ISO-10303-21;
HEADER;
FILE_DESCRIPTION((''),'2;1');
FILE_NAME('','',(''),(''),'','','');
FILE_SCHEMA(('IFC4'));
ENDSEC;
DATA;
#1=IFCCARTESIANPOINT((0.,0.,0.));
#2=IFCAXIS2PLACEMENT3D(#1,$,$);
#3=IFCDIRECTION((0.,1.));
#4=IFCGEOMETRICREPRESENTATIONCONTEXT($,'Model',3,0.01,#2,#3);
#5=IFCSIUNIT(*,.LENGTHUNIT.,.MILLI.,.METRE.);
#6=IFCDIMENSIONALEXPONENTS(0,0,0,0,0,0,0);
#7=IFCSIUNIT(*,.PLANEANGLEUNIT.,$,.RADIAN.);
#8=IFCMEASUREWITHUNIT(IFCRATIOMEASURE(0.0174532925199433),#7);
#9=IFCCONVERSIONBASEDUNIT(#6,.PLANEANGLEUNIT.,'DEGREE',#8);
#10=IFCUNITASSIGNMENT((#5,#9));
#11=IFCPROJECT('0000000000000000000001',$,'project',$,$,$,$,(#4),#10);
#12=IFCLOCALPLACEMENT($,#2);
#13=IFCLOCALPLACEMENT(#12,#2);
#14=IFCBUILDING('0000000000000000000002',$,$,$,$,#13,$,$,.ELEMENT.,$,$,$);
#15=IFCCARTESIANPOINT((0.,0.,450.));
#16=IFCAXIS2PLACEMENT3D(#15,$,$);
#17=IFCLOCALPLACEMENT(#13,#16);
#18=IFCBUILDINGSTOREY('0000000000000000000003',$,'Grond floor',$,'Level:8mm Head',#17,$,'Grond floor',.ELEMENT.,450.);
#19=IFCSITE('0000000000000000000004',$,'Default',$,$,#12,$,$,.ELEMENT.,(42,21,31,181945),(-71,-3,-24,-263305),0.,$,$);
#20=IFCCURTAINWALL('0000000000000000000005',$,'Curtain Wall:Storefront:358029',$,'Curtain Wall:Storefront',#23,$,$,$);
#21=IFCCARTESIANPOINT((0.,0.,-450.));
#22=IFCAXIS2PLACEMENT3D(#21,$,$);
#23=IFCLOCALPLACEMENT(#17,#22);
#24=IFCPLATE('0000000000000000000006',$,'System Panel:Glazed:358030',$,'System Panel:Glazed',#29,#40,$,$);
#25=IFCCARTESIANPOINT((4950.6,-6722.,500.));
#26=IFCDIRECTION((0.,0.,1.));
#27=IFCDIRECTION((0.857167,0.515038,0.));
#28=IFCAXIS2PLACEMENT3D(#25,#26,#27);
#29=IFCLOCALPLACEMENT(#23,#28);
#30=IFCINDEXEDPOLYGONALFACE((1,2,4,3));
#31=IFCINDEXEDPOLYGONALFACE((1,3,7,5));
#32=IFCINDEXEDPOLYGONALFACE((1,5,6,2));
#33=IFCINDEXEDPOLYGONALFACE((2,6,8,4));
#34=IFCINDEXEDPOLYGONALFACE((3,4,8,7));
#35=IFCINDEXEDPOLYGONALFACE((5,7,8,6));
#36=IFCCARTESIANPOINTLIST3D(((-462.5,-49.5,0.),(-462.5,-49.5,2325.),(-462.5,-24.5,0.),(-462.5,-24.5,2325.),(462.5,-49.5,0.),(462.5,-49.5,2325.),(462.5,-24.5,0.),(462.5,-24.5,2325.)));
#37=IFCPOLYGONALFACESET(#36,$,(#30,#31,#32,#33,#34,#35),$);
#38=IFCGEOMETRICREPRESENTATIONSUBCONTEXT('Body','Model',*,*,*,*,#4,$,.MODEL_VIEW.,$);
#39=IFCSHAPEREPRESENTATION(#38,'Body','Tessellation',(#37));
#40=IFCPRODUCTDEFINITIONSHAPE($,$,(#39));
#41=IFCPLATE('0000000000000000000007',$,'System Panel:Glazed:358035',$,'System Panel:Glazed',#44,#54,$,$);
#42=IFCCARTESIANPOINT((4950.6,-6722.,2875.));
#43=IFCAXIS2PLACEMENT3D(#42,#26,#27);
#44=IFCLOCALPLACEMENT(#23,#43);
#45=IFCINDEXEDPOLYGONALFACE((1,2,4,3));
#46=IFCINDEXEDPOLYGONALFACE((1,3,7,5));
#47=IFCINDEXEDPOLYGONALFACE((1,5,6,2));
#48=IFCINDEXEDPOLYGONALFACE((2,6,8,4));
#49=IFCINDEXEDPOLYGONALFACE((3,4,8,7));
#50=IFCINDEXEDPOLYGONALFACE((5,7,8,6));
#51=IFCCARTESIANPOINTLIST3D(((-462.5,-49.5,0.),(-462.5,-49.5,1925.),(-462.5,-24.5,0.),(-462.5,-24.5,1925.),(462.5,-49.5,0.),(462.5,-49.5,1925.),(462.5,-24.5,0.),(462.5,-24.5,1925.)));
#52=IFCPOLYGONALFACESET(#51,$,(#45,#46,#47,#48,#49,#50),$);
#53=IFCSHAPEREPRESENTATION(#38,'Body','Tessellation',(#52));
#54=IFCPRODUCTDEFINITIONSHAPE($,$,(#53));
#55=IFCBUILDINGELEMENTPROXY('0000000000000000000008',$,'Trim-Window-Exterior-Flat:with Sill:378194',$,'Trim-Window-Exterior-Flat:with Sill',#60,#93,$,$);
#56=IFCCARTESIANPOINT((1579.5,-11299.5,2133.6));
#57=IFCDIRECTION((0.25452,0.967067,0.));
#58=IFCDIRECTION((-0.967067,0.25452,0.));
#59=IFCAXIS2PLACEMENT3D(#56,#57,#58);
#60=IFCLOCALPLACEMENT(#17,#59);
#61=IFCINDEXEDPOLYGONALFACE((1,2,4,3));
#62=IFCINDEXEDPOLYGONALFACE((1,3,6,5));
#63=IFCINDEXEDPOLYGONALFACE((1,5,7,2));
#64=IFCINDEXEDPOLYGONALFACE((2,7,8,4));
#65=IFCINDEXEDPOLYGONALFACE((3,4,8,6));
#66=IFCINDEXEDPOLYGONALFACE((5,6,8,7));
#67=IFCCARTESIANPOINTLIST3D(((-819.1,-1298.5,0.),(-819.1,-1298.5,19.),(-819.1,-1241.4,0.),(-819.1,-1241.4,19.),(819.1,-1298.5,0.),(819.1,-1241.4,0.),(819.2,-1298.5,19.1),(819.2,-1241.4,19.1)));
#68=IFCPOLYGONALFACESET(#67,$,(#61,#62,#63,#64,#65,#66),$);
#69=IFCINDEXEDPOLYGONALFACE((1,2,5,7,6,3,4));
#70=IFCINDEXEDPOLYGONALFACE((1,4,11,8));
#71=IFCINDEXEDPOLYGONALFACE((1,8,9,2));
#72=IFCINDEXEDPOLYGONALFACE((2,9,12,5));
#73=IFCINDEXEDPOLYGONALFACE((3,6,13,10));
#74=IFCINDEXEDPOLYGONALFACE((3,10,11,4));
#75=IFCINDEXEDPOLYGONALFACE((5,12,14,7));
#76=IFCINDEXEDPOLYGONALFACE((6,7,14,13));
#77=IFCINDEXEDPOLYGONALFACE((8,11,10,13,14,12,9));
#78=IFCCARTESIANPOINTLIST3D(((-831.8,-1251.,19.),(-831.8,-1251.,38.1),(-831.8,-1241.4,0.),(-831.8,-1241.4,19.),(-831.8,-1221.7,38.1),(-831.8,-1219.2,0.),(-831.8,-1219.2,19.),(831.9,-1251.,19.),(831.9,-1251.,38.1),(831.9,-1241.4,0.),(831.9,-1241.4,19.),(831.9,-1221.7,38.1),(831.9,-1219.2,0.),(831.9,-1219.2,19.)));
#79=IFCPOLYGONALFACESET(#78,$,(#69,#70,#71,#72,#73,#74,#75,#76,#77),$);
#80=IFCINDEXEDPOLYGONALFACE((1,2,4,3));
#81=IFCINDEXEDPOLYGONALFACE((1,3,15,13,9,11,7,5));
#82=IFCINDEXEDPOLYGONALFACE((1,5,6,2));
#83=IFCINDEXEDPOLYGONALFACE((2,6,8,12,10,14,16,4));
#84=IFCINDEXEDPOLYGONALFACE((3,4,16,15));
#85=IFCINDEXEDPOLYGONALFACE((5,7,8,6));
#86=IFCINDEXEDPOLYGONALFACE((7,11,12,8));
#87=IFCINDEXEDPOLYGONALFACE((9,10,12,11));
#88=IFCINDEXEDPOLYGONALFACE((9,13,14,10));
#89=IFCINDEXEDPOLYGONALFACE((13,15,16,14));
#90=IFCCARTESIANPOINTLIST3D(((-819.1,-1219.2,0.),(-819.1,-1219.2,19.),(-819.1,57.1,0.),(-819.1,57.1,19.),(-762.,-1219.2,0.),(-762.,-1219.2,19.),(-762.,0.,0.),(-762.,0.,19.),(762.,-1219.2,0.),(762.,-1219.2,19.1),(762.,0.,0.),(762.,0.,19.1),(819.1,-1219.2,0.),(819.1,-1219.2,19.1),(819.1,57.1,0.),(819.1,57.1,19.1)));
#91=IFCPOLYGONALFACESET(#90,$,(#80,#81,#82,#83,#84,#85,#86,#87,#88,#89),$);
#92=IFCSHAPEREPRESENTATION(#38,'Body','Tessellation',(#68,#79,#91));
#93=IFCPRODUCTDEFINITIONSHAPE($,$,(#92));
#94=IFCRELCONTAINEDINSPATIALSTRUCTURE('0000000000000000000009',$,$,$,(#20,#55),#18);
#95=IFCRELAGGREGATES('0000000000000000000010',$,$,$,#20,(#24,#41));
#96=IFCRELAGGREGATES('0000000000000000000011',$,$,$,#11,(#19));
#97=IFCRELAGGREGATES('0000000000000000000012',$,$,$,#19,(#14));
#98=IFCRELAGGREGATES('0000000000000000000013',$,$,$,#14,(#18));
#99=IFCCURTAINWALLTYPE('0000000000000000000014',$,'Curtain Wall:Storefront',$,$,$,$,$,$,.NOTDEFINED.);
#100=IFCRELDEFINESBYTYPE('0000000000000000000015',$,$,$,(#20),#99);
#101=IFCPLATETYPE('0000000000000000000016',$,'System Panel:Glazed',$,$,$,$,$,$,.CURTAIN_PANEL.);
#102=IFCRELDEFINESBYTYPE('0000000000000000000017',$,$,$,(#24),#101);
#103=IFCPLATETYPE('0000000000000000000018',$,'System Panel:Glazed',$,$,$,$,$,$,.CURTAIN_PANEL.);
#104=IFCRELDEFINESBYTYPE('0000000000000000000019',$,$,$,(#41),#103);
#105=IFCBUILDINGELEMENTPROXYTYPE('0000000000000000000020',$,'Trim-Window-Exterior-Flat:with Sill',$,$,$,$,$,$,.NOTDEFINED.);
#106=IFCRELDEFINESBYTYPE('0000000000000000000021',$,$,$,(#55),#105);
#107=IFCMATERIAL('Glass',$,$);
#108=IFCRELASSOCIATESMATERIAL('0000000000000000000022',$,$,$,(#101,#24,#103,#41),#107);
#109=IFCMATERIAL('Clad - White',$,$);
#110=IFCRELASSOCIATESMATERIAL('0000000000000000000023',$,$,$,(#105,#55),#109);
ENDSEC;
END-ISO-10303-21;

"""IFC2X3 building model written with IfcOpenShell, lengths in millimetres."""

from ifc_helpers import new_model, entity, si_unit, converted_unit, direction, frame, frame_2d, origin, origin_2d_with_axis, place, context, subcontext, project, spatial, polyline, rectangle, outline, extrude, source, transform, mapped, material, type_object, type_shapes, element, aggregate, save


model = new_model("IFC2X3")

# Units and contexts
model_context = context("Model", 3, precision=0.01, world=origin(), true_north=direction((0.0, 1.0)))
body_context = subcontext(model_context, "Body", "Model", "MODEL_VIEW")
ifc_project = project(units=[si_unit("LENGTHUNIT", "METRE", prefix="MILLI"), converted_unit("PLANEANGLEUNIT", "DEGREE", entity("IfcRatioMeasure", 0.0174532925199433), si_unit("PLANEANGLEUNIT", "RADIAN"), dimensions=[0, 0, 0, 0, 0, 0, 0])], contexts=[model_context])

# Site, building, storey
site_placement = place(None, origin())
site = spatial("IfcSite", under=ifc_project, at=site_placement, Name="Default", CompositionType="ELEMENT", RefLatitude=(42, 21, 31, 181945), RefLongitude=(-71, -3, -24, -263305), RefElevation=0.0)
building_placement = place(site_placement, origin())
building = spatial("IfcBuilding", under=site, at=building_placement, CompositionType="ELEMENT")
storey_placement = place(building_placement, frame((0.0, 0.0, 450.0)))
storey = spatial("IfcBuildingStorey", under=building, at=storey_placement, Name="Grond floor", ObjectType="Level:8mm Head", LongName="Grond floor", CompositionType="ELEMENT", Elevation=450.0)

# Curtain wall, plates
curtain_wall_type = type_object("IfcCurtainWallType", Name="Curtain Wall:Storefront", PredefinedType="NOTDEFINED")
curtain_wall_placement = place(storey_placement, frame((0.0, 0.0, -450.0)))
curtain_wall = element("IfcCurtainWall", 1, at=curtain_wall_placement, inside=storey, type_object=curtain_wall_type, Name="Curtain Wall:Storefront:358029", ObjectType="Curtain Wall:Storefront")
ifc_material_1 = material(Name="Glass")
plate_type_1 = type_object("IfcPlateType", Name="System Panel:Glazed", PredefinedType="CURTAIN_PANEL", material=ifc_material_1)
shared_shape_1 = source(origin(), body_context, "Body", "SweptSolid", [
    extrude(rectangle(XDim=25.0, YDim=925.0, at=frame_2d((0.0, 0.0), x_axis=(1.0, 0.0))), frame((0.0, -37.0, 0.0), z_axis=(0.0, 0.0, 1.0), x_axis=(0.0, 1.0, 0.0)), (0.0, 0.0, 1.0), 2325.0),
])
type_shapes(plate_type_1, [shared_shape_1])
plate_1_placement = place(curtain_wall_placement, frame((4950.6, -6722.0, 500.0), z_axis=(0.0, 0.0, 1.0), x_axis=(0.857167, 0.515038, 0.0)))
plate_1 = element("IfcPlate", 2, at=plate_1_placement, type_object=plate_type_1, material=ifc_material_1, Name="System Panel:Glazed:358030", ObjectType="System Panel:Glazed", context=body_context, shape_type="MappedRepresentation", body=[
    mapped(shared_shape_1, transform((0.0, 0.0, 0.0), scale=1.0)),
])
plate_type_2 = type_object("IfcPlateType", Name="System Panel:Glazed", PredefinedType="CURTAIN_PANEL", material=ifc_material_1)
shared_shape_2 = source(origin(), body_context, "Body", "SweptSolid", [
    extrude(rectangle(XDim=25.0, YDim=925.0, at=frame_2d((0.0, 0.0), x_axis=(1.0, 0.0))), frame((0.0, -37.0, 0.0), z_axis=(0.0, 0.0, 1.0), x_axis=(0.0, 1.0, 0.0)), (0.0, 0.0, 1.0), 1925.0),
])
type_shapes(plate_type_2, [shared_shape_2])
plate_2_placement = place(curtain_wall_placement, frame((4950.6, -6722.0, 2875.0), z_axis=(0.0, 0.0, 1.0), x_axis=(0.857167, 0.515038, 0.0)))
plate_2 = element("IfcPlate", 3, at=plate_2_placement, type_object=plate_type_2, material=ifc_material_1, Name="System Panel:Glazed:358035", ObjectType="System Panel:Glazed", context=body_context, shape_type="MappedRepresentation", body=[
    mapped(shared_shape_2, transform((0.0, 0.0, 0.0), scale=1.0)),
])
aggregate(curtain_wall, [plate_1, plate_2])

# Building element proxy
ifc_material_2 = material(Name="Clad - White")
building_element_proxy_type_1 = type_object("IfcBuildingElementProxyType", Name="Trim-Window-Exterior-Flat:with Sill", PredefinedType="NOTDEFINED", material=ifc_material_2)
shared_shape_3 = source(origin(), body_context, "Body", "SweptSolid", [
    extrude(rectangle(XDim=1638.3, YDim=57.2, at=origin_2d_with_axis()), frame((0.0, -1270.0, 0.0), z_axis=(0.0, 0.0, 1.0), x_axis=(-1.0, 0.0, 0.0)), (0.0, 0.0, 1.0), 19.1),
    extrude(outline(polyline([(-19.0, -16.0), (0.0, -16.0), (0.0, -6.4), (19.0, -6.4), (19.0, 15.8), (0.0, 15.8), (-19.0, 13.3), (-19.0, -16.0)])), frame((-831.8, -1235.0, 19.0), z_axis=(1.0, 0.0, 0.0), x_axis=(0.0, 0.0, -1.0)), (0.0, 0.0, 1.0), 1663.7),
    extrude(outline(polyline([(-652.5, -819.1), (623.9, -819.1), (623.9, -762.0), (-595.3, -762.0), (-595.3, 762.0), (623.9, 762.0), (623.9, 819.1), (-652.5, 819.1), (-652.5, -819.1)])), frame((0.0, -595.3, 0.0), z_axis=(0.0, 0.0, 1.0), x_axis=(0.0, -1.0, 0.0)), (0.0, 0.0, 1.0), 19.1),
])
type_shapes(building_element_proxy_type_1, [shared_shape_3])
proxy_1_placement = place(storey_placement, frame((1579.5, -11299.5, 2133.6), z_axis=(0.25452, 0.967067, 0.0), x_axis=(-0.967067, 0.25452, 0.0)))
element("IfcBuildingElementProxy", 4, at=proxy_1_placement, inside=storey, type_object=building_element_proxy_type_1, material=ifc_material_2, Name="Trim-Window-Exterior-Flat:with Sill:378194", ObjectType="Trim-Window-Exterior-Flat:with Sill", context=body_context, shape_type="MappedRepresentation", body=[
    mapped(shared_shape_3, transform((0.0, 0.0, 0.0), scale=1.0)),
])

save(model, "model.ifc")
